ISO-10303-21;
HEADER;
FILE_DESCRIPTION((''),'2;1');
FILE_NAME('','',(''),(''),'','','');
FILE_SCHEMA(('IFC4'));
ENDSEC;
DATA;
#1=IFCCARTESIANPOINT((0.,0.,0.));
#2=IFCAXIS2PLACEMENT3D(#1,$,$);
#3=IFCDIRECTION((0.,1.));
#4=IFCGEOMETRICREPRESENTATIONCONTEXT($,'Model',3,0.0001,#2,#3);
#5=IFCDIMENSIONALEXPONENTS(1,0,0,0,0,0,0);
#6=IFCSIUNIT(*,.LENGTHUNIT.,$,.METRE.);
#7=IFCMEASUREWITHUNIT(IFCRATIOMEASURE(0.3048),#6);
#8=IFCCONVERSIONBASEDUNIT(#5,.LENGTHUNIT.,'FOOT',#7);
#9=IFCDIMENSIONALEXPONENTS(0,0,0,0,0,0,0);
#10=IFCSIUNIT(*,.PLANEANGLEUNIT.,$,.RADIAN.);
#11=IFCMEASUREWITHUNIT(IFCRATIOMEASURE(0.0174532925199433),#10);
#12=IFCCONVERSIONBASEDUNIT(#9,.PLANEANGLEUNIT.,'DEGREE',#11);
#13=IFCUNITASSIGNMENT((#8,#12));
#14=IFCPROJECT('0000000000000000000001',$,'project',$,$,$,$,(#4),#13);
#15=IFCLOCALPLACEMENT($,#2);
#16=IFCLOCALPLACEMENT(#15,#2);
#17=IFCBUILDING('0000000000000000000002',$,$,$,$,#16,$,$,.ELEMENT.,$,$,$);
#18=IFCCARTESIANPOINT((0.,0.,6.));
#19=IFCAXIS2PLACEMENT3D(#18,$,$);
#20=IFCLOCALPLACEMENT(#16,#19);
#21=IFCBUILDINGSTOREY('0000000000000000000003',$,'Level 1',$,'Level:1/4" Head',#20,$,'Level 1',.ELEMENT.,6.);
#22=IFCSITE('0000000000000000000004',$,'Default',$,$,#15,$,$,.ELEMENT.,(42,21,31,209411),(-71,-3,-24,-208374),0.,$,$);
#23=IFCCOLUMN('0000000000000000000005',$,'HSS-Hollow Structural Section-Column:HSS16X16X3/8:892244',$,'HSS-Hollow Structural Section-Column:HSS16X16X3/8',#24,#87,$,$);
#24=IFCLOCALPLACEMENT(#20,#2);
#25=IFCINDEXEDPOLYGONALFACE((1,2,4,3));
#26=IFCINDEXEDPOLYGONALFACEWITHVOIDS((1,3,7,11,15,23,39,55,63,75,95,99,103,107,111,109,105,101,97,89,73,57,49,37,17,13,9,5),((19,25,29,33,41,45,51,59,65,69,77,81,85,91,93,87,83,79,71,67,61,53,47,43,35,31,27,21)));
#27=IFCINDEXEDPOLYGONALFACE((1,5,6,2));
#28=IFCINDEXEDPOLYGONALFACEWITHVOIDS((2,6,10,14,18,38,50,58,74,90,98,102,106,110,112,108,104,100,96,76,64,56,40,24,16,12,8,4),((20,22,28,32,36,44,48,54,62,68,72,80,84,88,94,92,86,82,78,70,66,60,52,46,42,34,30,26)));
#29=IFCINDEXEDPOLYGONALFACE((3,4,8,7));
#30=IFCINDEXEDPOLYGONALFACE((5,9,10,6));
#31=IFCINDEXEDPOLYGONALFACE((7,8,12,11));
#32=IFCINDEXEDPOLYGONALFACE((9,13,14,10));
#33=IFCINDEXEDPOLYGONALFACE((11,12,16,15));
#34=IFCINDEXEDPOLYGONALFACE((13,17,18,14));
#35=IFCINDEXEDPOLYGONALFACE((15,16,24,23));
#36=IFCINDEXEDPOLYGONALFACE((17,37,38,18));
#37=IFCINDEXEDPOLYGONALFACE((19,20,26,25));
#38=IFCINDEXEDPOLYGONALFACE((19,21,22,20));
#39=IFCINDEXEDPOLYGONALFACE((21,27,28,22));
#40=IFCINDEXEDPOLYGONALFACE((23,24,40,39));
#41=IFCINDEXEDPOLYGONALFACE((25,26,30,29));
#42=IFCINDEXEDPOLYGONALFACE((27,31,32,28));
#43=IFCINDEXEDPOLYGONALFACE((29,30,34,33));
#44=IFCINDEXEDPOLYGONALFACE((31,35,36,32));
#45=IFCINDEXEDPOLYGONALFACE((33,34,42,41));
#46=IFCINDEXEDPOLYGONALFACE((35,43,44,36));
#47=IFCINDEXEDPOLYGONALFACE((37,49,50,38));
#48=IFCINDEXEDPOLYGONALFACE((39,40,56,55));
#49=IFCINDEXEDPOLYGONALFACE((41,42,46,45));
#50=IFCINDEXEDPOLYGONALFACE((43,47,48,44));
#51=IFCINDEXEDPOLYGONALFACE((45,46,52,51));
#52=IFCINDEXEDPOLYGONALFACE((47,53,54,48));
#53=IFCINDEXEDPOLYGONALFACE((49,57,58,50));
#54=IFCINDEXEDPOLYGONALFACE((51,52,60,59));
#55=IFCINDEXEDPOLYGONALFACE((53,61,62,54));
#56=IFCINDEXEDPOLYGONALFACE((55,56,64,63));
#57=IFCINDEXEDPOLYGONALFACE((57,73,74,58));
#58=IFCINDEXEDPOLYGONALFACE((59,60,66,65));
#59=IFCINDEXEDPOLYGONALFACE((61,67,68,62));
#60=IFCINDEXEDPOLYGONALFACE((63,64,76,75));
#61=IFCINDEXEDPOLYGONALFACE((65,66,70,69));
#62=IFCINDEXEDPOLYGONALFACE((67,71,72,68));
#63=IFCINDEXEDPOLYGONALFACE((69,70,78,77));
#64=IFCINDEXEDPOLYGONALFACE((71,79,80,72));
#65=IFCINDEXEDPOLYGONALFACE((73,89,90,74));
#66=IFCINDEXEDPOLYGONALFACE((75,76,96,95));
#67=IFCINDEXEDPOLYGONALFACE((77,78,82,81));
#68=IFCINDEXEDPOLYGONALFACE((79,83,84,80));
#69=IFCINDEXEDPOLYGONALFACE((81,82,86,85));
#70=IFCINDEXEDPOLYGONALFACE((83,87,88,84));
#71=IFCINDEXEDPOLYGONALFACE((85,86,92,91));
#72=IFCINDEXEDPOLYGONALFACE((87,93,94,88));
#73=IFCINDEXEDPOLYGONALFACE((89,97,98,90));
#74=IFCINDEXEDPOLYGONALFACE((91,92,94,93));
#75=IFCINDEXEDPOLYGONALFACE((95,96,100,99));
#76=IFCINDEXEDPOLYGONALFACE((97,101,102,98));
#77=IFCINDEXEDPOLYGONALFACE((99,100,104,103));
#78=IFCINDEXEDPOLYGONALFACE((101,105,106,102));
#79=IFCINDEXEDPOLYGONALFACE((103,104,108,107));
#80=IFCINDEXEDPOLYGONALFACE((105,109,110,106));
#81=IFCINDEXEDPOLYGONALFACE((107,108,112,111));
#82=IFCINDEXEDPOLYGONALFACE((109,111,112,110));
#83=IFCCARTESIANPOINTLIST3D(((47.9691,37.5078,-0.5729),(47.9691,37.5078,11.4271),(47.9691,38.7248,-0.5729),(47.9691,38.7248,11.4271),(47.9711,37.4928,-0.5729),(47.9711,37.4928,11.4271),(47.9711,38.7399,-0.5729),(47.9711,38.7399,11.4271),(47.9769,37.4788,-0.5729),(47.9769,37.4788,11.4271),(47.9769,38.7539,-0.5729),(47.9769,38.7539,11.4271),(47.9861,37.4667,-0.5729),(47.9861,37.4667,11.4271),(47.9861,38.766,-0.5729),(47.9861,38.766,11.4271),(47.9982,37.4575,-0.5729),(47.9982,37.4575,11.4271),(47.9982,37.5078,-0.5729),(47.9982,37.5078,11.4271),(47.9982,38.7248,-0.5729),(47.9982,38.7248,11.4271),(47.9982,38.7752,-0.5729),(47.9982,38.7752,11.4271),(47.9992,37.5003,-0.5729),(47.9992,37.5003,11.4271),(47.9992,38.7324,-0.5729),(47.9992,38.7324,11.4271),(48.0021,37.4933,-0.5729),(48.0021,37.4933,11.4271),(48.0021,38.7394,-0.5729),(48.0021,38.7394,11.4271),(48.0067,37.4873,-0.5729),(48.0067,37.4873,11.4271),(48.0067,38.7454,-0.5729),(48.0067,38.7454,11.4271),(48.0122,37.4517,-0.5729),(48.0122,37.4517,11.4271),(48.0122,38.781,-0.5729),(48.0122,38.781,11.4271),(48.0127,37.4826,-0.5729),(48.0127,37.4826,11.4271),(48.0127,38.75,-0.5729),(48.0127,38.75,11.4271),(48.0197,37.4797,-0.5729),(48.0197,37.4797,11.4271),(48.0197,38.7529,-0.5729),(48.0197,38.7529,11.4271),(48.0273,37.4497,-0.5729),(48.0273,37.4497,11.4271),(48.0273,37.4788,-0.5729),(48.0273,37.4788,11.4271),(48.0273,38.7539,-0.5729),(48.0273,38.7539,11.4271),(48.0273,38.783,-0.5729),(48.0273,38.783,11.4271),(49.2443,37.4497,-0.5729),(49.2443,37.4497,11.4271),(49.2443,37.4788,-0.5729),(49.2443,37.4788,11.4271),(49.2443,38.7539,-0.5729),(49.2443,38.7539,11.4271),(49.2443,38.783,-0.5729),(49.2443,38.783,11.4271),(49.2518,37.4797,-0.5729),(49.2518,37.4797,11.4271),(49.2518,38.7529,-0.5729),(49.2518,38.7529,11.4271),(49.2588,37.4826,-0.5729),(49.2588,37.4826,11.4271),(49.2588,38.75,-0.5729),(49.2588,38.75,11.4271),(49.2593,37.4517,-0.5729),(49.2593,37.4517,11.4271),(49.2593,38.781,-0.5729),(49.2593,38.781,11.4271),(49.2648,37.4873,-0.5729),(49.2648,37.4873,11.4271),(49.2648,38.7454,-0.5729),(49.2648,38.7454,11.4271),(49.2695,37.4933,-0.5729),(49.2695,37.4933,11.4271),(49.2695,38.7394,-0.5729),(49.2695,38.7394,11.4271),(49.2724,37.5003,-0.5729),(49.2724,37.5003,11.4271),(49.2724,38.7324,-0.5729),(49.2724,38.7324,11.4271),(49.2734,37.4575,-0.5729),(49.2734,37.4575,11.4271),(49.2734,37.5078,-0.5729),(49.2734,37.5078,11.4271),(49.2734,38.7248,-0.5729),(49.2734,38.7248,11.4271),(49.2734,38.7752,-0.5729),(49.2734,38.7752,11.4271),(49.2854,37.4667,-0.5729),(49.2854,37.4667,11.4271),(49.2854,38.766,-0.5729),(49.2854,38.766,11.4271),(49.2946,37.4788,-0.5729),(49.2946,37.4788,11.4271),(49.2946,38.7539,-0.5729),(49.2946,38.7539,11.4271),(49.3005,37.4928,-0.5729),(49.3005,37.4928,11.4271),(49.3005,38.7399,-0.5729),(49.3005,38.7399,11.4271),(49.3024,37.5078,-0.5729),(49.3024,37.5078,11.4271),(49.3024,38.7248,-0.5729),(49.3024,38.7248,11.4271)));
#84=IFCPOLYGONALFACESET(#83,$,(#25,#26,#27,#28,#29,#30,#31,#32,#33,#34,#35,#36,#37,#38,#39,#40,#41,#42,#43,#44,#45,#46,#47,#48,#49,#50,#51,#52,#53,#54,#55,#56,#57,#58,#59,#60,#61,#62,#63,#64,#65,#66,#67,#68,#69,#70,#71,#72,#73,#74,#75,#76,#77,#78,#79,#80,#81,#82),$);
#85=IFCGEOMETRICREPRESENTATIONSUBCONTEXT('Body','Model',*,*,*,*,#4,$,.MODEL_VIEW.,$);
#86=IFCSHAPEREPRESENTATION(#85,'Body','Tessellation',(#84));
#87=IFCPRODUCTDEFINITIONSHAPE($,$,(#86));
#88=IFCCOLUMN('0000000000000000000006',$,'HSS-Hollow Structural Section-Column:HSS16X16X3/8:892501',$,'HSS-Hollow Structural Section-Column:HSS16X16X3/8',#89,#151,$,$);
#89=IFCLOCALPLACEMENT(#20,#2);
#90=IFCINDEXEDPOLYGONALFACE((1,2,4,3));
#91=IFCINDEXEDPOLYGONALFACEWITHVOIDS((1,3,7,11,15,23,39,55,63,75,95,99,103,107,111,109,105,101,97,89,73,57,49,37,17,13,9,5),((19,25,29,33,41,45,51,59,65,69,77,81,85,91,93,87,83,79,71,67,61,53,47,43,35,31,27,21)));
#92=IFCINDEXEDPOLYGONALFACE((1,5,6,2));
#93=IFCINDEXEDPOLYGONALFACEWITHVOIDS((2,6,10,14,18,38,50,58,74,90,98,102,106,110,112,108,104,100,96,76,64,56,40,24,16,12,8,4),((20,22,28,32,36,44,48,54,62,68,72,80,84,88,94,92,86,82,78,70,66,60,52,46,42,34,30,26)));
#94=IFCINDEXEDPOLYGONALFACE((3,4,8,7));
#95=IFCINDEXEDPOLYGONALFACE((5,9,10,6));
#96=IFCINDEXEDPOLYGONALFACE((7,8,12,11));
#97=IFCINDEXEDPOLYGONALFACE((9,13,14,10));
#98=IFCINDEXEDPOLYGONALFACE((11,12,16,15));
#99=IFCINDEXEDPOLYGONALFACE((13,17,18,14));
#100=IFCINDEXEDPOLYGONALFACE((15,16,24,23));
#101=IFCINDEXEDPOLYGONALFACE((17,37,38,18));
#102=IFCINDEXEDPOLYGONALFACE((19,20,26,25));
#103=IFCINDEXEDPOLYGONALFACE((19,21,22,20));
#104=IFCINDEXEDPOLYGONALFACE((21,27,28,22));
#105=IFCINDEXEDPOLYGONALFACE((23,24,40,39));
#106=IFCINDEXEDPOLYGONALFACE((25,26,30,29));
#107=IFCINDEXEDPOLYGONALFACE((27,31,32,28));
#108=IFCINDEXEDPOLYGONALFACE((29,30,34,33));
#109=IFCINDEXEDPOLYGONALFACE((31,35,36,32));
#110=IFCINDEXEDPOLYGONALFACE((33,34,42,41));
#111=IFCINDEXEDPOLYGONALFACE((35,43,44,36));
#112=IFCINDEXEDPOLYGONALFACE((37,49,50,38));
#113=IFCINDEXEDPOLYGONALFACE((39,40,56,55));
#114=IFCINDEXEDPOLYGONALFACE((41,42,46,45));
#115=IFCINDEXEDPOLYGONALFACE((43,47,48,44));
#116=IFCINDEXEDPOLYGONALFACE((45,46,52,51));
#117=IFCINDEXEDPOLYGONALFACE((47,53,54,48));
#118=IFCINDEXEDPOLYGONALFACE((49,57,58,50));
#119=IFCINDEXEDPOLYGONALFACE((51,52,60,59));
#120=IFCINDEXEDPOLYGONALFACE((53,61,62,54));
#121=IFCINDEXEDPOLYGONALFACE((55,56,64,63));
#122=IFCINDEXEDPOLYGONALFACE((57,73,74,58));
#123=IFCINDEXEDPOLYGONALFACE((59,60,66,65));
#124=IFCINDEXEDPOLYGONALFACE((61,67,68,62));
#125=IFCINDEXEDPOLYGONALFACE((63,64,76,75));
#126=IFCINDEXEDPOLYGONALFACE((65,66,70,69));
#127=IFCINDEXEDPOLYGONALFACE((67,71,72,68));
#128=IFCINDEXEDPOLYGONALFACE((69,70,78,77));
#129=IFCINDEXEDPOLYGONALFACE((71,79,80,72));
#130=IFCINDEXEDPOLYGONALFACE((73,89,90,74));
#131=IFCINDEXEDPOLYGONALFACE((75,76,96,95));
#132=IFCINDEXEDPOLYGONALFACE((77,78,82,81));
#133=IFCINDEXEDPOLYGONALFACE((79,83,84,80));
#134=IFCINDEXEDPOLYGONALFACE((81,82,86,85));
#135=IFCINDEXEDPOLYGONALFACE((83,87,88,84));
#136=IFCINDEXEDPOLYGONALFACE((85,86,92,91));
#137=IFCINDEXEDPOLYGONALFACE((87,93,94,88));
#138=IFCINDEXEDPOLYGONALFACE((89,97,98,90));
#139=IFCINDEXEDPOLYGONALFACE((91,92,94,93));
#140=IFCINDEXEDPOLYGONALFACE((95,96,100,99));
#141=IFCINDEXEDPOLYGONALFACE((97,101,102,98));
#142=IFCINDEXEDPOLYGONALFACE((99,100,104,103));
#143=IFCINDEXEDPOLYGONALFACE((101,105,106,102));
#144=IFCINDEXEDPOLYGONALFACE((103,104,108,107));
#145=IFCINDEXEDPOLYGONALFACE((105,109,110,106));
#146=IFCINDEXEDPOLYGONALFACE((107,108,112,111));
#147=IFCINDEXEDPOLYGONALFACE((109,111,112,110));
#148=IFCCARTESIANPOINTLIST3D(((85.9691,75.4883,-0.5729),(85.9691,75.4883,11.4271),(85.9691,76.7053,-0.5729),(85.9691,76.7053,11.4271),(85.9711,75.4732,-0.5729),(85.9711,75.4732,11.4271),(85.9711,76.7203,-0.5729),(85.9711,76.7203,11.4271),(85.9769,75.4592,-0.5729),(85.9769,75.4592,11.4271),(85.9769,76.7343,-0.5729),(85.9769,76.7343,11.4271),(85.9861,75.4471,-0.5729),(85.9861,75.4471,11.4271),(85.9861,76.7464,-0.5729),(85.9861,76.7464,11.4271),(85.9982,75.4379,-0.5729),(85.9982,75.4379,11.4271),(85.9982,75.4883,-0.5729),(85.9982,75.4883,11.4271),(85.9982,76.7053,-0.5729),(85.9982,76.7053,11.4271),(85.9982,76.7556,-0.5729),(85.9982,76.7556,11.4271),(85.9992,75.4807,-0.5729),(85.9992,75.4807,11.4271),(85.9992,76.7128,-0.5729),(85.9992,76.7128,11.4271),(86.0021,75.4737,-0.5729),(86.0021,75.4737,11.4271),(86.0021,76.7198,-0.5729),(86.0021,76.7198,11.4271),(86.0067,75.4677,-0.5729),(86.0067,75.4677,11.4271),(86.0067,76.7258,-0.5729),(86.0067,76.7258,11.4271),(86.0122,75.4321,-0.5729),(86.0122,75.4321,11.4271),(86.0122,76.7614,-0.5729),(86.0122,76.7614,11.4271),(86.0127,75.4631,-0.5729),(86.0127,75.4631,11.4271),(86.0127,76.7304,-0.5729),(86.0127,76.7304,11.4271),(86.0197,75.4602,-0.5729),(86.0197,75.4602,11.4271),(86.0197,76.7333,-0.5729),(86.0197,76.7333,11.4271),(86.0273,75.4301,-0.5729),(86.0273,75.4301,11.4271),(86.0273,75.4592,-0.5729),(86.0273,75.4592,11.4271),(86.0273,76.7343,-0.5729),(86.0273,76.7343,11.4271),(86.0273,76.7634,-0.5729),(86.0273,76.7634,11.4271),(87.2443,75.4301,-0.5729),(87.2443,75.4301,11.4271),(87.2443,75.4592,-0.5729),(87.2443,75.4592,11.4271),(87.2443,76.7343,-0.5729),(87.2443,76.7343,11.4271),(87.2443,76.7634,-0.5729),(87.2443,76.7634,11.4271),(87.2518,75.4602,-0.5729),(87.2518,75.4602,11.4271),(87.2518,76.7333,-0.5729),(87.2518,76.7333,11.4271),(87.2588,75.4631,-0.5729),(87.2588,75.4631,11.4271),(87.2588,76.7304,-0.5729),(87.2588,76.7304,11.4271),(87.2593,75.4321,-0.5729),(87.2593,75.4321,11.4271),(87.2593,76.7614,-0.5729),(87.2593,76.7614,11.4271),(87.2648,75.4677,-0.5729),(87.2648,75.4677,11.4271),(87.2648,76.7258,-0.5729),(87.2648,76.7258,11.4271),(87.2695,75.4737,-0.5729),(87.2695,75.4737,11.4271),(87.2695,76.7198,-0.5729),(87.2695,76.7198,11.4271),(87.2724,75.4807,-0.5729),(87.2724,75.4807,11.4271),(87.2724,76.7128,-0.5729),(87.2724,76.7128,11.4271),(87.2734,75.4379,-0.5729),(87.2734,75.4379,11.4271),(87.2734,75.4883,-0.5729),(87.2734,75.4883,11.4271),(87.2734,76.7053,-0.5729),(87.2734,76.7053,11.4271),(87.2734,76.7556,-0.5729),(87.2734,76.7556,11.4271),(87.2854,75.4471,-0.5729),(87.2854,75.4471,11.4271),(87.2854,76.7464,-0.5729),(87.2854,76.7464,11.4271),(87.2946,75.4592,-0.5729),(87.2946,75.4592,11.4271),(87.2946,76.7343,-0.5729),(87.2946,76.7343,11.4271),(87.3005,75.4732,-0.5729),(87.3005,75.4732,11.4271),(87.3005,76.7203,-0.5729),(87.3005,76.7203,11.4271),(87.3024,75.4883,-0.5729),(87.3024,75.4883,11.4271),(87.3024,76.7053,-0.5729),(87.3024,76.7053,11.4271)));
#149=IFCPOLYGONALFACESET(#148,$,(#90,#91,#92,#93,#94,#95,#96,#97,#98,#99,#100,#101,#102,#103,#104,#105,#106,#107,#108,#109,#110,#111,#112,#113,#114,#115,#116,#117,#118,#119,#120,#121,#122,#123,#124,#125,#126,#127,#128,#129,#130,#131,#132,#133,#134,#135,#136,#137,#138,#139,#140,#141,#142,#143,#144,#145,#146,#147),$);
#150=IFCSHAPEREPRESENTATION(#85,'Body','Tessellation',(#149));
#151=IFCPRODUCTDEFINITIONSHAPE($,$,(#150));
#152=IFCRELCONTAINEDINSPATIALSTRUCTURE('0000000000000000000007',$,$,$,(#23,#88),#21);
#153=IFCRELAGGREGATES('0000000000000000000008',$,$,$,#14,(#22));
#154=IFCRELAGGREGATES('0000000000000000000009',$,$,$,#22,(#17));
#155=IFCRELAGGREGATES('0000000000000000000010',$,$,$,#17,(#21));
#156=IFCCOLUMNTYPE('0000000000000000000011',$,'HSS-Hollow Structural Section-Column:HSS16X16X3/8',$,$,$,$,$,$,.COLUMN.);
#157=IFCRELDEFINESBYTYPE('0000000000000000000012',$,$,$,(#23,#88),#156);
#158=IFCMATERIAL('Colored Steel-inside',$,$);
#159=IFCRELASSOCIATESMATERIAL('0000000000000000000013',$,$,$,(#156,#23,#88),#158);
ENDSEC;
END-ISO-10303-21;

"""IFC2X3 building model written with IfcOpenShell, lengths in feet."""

from ifc_helpers import new_model, entity, si_unit, converted_unit, direction, frame, frame_2d, origin, place, context, subcontext, project, spatial, polyline, circle_curve, parameter, trimmed, segment, composite_curve, outline, extrude, source, transform, mapped, material, type_object, type_shapes, element, save


model = new_model("IFC2X3")

# Units and contexts
model_context = context("Model", 3, precision=0.0001, world=origin(), true_north=direction((0.0, 1.0)))
body_context = subcontext(model_context, "Body", "Model", "MODEL_VIEW")
ifc_project = project(units=[converted_unit("LENGTHUNIT", "FOOT", entity("IfcRatioMeasure", 0.3048), si_unit("LENGTHUNIT", "METRE"), dimensions=[1, 0, 0, 0, 0, 0, 0]), converted_unit("PLANEANGLEUNIT", "DEGREE", entity("IfcRatioMeasure", 0.0174532925199433), si_unit("PLANEANGLEUNIT", "RADIAN"), dimensions=[0, 0, 0, 0, 0, 0, 0])], contexts=[model_context])

# Site, building, storey
site_placement = place(None, origin())
site = spatial("IfcSite", under=ifc_project, at=site_placement, Name="Default", CompositionType="ELEMENT", RefLatitude=(42, 21, 31, 209411), RefLongitude=(-71, -3, -24, -208374), RefElevation=0.0)
building_placement = place(site_placement, origin())
building = spatial("IfcBuilding", under=site, at=building_placement, CompositionType="ELEMENT")
storey_placement = place(building_placement, frame((0.0, 0.0, 6.0)))
storey = spatial("IfcBuildingStorey", under=building, at=storey_placement, Name="Level 1", ObjectType="Level:1/4\" Head", LongName="Level 1", CompositionType="ELEMENT", Elevation=6.0)

# Columns
ifc_material_1 = material(Name="Colored Steel-inside")
column_type_1 = type_object("IfcColumnType", Name="HSS-Hollow Structural Section-Column:HSS16X16X3/8", PredefinedType="COLUMN", material=ifc_material_1)
shared_shape_1 = source(origin(), body_context, "Body", "SweptSolid", [
    extrude(outline(composite_curve([segment(polyline([(-0.6085, -0.6667), (0.6085, -0.6667)]), True, "CONTINUOUS"), segment(trimmed(circle_curve(frame_2d((0.6085, -0.6085), x_axis=(-1.0, 0.0)), 0.0582), [parameter(90.0)], [parameter(180.0)], True, "PARAMETER"), True, "CONTINUOUS"), segment(polyline([(0.6667, -0.6085), (0.6667, 0.6085)]), True, "CONTINUOUS"), segment(trimmed(circle_curve(frame_2d((0.6085, 0.6085), x_axis=(-1.0, 0.0)), 0.0582), [parameter(180.0)], [parameter(270.0)], True, "PARAMETER"), True, "CONTINUOUS"), segment(polyline([(0.6085, 0.6667), (-0.6085, 0.6667)]), True, "CONTINUOUS"), segment(trimmed(circle_curve(frame_2d((-0.6085, 0.6085), x_axis=(-1.0, 0.0)), 0.0582), [parameter(270.0)], [parameter(360.0)], True, "PARAMETER"), True, "CONTINUOUS"), segment(polyline([(-0.6667, 0.6085), (-0.6667, -0.6085)]), True, "CONTINUOUS"), segment(trimmed(circle_curve(frame_2d((-0.6085, -0.6085), x_axis=(-1.0, 0.0)), 0.0582), [parameter(360.0)], [parameter(90.0)], True, "PARAMETER"), True, "CONTINUOUS")], self_intersect=False), holes=[composite_curve([segment(trimmed(circle_curve(frame_2d((-0.6085, -0.6085), x_axis=(-1.0, 0.0)), 0.0291), [parameter(0.0)], [parameter(90.0)], True, "PARAMETER"), False, "CONTINUOUS"), segment(polyline([(-0.6376, -0.6085), (-0.6376, 0.6085)]), True, "CONTINUOUS"), segment(trimmed(circle_curve(frame_2d((-0.6085, 0.6085), x_axis=(-1.0, 0.0)), 0.0291), [parameter(270.0)], [parameter(360.0)], True, "PARAMETER"), False, "CONTINUOUS"), segment(polyline([(-0.6085, 0.6376), (0.6085, 0.6376)]), True, "CONTINUOUS"), segment(trimmed(circle_curve(frame_2d((0.6085, 0.6085), x_axis=(-1.0, 0.0)), 0.0291), [parameter(180.0)], [parameter(270.0)], True, "PARAMETER"), False, "CONTINUOUS"), segment(polyline([(0.6376, 0.6085), (0.6376, -0.6085)]), True, "CONTINUOUS"), segment(trimmed(circle_curve(frame_2d((0.6085, -0.6085), x_axis=(-1.0, 0.0)), 0.0291), [parameter(90.0)], [parameter(180.0)], True, "PARAMETER"), False, "CONTINUOUS"), segment(polyline([(0.6085, -0.6376), (-0.6085, -0.6376)]), True, "CONTINUOUS")], self_intersect=False)]), frame((0.0, 0.0, 5.4271), z_axis=(0.0, 0.0, 1.0), x_axis=(-1.0, 0.0, 0.0)), (0.0, 0.0, 1.0), 12.0),
])
type_shapes(column_type_1, [shared_shape_1])
for number, where, name in (
    (1, (48.6358, 38.1163, -6.0), "HSS-Hollow Structural Section-Column:HSS16X16X3/8:892244"),
    (2, (86.6358, 76.0968, -6.0), "HSS-Hollow Structural Section-Column:HSS16X16X3/8:892501"),
):
    element("IfcColumn", number, at=place(storey_placement, frame(where)), inside=storey, type_object=column_type_1, material=ifc_material_1, Name=name, ObjectType="HSS-Hollow Structural Section-Column:HSS16X16X3/8", context=body_context, shape_type="MappedRepresentation", body=[
        mapped(shared_shape_1, transform((0.0, 0.0, 0.0), scale=1.0)),
    ])

save(model, "model.ifc")
